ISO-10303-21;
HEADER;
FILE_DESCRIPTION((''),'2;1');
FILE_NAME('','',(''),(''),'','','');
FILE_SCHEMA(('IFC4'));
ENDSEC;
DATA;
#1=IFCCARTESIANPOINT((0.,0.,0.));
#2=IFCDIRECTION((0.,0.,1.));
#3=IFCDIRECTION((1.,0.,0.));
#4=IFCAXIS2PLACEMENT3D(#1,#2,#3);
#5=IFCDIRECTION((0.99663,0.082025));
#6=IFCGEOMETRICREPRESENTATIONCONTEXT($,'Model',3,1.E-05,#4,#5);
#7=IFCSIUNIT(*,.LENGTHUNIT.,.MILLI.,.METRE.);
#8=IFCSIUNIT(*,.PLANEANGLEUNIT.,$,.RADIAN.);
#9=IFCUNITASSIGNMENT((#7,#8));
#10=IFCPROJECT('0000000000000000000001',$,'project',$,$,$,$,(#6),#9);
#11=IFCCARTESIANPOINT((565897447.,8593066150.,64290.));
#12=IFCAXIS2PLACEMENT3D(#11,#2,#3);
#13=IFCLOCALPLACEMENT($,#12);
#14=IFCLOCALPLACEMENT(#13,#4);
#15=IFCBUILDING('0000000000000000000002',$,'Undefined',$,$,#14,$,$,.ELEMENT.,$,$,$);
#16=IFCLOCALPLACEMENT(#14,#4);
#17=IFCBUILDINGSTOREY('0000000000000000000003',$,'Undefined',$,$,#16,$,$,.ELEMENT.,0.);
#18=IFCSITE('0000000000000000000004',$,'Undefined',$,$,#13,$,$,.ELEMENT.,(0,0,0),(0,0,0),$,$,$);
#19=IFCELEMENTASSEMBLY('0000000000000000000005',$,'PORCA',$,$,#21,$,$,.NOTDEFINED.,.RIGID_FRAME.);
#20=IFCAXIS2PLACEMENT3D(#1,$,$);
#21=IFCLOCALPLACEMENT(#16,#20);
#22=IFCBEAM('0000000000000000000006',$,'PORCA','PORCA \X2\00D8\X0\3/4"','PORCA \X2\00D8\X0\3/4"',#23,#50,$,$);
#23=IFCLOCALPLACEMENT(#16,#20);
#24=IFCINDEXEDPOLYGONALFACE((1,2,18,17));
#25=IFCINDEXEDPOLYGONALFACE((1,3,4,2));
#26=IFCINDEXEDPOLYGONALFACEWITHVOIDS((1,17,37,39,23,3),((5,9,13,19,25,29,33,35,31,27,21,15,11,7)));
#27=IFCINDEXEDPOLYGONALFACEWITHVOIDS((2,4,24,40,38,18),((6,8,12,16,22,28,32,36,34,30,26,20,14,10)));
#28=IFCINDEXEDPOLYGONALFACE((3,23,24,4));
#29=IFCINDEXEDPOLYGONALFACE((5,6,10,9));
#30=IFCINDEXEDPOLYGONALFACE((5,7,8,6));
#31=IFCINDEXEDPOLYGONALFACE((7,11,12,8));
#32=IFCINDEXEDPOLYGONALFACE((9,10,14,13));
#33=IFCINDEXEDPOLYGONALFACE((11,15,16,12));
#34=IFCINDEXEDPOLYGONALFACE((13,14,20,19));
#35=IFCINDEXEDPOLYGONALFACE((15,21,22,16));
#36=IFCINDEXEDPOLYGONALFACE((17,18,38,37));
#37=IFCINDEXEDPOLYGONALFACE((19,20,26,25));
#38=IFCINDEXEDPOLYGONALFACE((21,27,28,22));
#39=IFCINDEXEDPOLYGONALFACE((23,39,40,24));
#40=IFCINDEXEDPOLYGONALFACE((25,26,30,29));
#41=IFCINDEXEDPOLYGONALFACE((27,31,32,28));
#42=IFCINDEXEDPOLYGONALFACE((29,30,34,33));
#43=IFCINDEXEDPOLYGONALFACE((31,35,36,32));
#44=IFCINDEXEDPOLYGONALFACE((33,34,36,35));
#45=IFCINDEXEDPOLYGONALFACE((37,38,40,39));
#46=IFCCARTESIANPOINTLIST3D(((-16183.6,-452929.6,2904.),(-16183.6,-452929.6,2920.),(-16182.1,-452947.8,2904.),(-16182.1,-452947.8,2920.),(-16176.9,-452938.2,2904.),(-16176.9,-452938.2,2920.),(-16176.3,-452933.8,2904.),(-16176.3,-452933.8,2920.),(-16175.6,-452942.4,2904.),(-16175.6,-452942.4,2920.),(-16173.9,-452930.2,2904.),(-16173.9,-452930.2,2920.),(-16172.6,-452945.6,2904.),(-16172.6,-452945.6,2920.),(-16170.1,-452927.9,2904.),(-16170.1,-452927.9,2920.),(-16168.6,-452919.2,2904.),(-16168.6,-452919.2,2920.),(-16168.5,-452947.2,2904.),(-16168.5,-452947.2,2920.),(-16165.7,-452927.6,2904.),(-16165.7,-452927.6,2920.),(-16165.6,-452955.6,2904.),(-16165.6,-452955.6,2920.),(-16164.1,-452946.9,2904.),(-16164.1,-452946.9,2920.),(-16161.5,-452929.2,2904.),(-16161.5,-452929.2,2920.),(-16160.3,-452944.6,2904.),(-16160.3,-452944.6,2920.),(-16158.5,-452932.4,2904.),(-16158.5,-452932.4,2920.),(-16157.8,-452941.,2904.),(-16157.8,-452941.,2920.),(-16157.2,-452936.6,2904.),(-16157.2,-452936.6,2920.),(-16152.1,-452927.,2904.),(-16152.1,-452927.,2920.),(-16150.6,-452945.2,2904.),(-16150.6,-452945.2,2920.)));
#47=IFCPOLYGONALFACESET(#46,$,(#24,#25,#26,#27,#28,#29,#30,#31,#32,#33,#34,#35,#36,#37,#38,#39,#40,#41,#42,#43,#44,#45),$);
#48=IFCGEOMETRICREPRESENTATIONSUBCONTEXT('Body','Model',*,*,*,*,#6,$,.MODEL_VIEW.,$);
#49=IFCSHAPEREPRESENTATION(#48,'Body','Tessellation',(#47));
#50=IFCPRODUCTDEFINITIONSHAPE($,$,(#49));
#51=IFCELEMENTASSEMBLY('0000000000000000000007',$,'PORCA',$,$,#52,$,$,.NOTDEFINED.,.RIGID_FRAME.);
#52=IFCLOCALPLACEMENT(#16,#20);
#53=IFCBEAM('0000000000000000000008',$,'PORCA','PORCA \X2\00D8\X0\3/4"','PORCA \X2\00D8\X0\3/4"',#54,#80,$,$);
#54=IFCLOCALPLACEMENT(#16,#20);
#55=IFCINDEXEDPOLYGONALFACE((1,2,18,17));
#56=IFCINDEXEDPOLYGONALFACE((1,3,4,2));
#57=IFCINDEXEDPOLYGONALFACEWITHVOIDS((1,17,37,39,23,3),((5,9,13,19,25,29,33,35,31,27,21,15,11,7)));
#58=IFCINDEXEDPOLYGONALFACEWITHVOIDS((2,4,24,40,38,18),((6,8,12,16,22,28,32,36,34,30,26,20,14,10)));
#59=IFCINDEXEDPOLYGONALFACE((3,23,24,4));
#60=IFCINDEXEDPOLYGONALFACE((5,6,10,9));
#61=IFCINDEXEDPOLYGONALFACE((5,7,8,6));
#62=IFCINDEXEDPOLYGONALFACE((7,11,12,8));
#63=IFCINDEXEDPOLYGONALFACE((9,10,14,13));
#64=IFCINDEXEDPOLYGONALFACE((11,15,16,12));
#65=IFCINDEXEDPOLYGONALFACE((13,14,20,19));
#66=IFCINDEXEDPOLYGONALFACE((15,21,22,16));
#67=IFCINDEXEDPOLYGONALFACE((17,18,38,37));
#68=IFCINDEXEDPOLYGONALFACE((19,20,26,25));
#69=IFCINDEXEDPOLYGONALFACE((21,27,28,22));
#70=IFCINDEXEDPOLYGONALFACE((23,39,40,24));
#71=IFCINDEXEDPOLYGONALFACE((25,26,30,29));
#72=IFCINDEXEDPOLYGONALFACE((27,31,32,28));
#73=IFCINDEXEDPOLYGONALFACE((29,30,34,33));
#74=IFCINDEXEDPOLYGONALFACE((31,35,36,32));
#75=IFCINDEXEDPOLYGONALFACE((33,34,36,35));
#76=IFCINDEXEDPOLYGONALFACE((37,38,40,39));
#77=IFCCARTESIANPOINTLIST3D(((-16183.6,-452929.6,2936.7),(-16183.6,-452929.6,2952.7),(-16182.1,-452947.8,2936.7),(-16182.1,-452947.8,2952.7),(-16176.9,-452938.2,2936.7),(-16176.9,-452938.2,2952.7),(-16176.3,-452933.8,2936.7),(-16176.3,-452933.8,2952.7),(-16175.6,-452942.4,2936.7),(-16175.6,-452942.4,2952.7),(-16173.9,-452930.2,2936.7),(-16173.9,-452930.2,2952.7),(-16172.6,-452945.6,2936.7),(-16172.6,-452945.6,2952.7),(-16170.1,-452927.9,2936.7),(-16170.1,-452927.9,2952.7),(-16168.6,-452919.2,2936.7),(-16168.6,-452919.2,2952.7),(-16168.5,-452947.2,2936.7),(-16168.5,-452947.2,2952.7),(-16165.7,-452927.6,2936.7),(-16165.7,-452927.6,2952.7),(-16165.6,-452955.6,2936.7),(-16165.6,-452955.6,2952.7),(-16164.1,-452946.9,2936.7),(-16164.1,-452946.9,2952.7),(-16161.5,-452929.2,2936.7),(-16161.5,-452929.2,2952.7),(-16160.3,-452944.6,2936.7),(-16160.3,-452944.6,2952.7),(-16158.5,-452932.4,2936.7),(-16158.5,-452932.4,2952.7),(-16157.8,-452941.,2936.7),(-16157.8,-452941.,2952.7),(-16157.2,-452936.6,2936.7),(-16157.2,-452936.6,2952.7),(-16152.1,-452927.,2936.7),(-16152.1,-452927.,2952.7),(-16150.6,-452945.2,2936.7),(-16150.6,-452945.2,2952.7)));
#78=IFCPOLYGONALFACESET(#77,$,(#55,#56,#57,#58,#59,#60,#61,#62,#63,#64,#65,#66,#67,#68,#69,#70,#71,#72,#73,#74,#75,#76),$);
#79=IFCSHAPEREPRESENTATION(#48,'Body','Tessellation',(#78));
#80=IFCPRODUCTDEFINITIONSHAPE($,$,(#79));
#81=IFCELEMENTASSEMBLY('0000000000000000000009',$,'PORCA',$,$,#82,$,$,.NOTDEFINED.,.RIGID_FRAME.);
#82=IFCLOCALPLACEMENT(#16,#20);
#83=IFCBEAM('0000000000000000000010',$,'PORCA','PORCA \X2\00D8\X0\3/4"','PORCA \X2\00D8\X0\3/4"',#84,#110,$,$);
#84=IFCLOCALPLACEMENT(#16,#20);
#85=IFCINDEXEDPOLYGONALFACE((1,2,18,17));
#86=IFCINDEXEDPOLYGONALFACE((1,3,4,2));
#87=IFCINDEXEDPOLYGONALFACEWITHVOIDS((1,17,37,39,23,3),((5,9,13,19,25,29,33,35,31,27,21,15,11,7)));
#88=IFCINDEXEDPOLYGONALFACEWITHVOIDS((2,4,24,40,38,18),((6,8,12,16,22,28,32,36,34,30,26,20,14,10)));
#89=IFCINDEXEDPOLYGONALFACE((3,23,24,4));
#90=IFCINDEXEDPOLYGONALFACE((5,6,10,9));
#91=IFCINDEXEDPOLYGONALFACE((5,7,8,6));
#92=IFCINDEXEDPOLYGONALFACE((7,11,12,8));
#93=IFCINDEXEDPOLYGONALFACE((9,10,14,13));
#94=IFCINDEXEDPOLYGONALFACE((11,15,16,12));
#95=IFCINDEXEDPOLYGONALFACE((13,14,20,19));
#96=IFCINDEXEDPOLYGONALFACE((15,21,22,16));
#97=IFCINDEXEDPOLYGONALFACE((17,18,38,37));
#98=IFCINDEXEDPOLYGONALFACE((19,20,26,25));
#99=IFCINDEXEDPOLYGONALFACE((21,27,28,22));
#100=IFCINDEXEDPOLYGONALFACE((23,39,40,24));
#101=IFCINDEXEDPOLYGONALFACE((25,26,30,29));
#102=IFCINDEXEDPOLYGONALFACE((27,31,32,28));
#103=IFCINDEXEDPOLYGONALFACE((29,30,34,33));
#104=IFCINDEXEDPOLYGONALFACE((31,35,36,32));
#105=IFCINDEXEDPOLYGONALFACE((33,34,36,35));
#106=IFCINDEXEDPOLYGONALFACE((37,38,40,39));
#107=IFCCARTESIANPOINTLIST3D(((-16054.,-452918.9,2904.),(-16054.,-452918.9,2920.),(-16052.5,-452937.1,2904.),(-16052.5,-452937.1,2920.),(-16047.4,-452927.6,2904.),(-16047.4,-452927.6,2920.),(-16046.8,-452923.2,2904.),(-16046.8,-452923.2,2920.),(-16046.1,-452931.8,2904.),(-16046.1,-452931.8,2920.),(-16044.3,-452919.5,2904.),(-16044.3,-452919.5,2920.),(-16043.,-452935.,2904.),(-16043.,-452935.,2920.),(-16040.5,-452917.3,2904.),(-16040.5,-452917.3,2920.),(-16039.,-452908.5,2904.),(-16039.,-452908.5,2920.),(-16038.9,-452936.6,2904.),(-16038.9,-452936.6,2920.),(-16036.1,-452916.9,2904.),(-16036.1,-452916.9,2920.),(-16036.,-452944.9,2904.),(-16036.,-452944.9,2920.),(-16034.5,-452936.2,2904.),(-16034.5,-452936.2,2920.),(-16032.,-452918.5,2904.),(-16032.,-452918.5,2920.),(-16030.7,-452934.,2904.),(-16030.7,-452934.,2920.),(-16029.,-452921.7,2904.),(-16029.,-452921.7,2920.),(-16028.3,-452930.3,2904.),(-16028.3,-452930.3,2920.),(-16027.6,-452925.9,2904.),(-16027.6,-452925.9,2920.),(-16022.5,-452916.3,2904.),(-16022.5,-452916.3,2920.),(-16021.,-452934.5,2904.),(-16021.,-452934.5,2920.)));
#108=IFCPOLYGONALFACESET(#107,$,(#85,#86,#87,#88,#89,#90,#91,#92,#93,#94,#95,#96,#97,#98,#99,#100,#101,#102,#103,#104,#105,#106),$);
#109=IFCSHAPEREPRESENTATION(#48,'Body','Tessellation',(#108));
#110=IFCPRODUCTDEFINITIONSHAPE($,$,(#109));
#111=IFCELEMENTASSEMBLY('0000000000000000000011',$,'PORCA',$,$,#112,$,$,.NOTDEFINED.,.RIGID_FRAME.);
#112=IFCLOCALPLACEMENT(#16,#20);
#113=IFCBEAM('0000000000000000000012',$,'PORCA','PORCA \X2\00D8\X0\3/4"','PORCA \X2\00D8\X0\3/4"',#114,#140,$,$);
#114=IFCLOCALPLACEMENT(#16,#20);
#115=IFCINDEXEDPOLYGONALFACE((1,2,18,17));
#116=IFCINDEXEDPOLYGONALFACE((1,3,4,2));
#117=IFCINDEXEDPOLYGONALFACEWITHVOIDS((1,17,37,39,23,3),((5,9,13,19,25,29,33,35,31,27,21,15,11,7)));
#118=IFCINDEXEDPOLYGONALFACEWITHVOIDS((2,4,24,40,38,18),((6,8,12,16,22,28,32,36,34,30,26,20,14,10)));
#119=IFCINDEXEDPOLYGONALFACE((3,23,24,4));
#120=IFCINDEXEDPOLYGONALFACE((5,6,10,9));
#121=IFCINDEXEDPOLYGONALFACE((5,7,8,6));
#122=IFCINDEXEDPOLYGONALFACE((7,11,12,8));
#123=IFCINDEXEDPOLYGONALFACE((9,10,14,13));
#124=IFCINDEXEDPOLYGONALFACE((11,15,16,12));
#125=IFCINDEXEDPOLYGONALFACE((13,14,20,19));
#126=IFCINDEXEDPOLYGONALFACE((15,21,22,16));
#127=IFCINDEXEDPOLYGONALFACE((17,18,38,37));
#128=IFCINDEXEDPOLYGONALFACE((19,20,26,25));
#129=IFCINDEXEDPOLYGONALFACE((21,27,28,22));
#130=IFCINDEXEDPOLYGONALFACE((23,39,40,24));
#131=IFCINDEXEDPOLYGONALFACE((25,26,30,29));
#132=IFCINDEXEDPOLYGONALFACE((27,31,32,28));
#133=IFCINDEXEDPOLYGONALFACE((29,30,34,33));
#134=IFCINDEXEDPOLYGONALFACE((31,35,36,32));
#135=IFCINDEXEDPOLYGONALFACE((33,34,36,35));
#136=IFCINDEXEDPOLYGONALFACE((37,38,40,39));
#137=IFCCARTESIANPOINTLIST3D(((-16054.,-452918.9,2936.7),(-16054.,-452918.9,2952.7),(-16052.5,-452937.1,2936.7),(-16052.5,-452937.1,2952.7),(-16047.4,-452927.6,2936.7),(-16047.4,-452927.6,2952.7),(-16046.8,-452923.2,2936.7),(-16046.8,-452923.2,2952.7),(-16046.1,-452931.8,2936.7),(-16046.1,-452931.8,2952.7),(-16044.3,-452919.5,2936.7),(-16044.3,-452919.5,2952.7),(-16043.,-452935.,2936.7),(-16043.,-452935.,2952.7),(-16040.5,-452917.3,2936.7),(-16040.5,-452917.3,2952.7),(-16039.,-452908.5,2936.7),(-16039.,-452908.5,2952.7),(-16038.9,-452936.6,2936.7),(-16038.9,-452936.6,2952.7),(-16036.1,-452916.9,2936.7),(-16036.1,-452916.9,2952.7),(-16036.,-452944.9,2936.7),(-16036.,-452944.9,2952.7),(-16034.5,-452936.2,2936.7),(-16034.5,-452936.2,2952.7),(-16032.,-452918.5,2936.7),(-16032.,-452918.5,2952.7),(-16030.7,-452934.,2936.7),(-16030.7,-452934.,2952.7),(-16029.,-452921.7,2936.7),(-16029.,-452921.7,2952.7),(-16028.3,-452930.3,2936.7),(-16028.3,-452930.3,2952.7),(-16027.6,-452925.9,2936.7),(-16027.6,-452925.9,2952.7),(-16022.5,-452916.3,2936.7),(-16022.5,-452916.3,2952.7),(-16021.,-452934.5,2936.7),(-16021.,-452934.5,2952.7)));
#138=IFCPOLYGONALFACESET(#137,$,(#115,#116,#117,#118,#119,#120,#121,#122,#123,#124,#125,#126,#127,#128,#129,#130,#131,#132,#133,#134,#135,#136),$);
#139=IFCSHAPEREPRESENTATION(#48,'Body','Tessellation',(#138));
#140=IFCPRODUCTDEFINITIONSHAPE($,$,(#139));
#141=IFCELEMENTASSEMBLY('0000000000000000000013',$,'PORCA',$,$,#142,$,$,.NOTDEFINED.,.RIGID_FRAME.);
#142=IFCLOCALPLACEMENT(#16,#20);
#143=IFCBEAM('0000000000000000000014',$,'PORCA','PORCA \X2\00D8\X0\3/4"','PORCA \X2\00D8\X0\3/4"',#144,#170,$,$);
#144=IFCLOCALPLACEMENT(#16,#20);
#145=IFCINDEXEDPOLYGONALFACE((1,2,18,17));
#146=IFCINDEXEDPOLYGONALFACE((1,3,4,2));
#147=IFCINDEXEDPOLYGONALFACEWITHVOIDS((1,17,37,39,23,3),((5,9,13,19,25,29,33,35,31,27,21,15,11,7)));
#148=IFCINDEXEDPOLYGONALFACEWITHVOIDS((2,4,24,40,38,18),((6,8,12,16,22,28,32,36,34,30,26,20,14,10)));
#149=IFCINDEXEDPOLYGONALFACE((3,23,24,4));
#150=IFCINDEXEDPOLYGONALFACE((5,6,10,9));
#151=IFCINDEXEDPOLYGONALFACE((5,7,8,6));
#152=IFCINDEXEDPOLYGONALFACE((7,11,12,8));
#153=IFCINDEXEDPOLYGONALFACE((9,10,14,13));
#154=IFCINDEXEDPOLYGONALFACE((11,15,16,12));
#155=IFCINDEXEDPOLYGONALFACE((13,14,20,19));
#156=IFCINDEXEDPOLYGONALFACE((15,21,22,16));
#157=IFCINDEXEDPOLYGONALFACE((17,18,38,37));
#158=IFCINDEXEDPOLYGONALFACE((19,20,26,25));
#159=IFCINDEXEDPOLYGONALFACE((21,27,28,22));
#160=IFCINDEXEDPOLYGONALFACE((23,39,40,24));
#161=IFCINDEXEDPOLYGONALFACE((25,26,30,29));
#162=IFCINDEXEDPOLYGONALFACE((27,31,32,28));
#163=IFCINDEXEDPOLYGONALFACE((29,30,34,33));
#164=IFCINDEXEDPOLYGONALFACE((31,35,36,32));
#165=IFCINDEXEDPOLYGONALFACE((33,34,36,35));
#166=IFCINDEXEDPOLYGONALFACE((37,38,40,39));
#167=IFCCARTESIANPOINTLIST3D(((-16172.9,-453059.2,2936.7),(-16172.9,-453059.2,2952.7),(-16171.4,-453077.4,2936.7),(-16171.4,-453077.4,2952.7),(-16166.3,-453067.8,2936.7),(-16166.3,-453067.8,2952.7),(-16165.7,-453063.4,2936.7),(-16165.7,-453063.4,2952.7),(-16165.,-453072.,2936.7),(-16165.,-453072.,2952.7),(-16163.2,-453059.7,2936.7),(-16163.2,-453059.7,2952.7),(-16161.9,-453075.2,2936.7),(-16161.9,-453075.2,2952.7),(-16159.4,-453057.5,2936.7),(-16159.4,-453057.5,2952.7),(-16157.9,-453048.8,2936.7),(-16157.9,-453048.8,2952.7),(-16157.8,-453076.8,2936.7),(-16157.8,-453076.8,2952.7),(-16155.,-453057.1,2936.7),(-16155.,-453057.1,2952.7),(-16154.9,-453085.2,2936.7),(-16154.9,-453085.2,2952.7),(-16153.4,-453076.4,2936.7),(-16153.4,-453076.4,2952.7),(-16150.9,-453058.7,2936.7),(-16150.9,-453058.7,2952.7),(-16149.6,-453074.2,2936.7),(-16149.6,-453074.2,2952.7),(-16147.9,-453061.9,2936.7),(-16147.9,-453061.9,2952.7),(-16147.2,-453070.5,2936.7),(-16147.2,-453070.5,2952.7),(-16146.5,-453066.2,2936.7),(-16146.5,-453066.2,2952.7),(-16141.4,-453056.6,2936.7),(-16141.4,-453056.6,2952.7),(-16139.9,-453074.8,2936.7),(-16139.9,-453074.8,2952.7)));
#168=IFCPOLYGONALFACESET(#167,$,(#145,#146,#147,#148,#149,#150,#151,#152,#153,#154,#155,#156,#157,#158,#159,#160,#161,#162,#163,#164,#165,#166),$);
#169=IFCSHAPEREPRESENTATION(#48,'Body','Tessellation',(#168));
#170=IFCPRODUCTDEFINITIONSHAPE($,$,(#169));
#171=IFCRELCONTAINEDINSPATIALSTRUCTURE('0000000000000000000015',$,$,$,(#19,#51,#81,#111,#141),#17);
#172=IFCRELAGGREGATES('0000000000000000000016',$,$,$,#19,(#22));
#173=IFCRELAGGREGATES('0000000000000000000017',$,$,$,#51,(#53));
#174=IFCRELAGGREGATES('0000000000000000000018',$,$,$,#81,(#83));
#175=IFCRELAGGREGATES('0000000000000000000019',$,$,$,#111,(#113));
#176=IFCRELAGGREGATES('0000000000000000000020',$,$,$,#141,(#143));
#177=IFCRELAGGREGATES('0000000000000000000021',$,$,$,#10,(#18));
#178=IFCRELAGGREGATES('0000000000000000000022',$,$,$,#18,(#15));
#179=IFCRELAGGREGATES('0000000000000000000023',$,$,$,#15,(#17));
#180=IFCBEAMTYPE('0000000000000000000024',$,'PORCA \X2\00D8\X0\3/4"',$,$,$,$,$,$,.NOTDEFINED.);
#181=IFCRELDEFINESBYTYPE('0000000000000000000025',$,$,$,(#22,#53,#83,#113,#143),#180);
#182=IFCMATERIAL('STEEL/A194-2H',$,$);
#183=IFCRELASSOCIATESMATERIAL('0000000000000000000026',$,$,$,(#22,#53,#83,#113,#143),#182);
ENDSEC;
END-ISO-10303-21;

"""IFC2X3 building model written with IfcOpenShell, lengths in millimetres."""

from ifc_helpers import new_model, si_unit, direction, frame, origin_with_axes, place, context, subcontext, project, spatial, polyline, outline, extrude, material, type_object, element, aggregate, save


model = new_model("IFC2X3")

# Units and contexts
model_context = context("Model", 3, precision=1e-05, world=origin_with_axes(), true_north=direction((0.99663, 0.082025)))
body_context = subcontext(model_context, "Body", "Model", "MODEL_VIEW")
ifc_project = project(units=[si_unit("LENGTHUNIT", "METRE", prefix="MILLI"), si_unit("PLANEANGLEUNIT", "RADIAN")], contexts=[model_context])

# Site, building, storey
site_placement = place(None, frame((565897447.0, 8593066150.0, 64290.0), z_axis=(0.0, 0.0, 1.0), x_axis=(1.0, 0.0, 0.0)))
site = spatial("IfcSite", under=ifc_project, at=site_placement, Name="Undefined", CompositionType="ELEMENT", RefLatitude=(0, 0, 0), RefLongitude=(0, 0, 0))
building_placement = place(site_placement, origin_with_axes())
building = spatial("IfcBuilding", under=site, at=building_placement, Name="Undefined", CompositionType="ELEMENT")
storey_placement = place(building_placement, origin_with_axes())
storey = spatial("IfcBuildingStorey", under=building, at=storey_placement, Name="Undefined", CompositionType="ELEMENT", Elevation=0.0)

# Element assemblies, beams
assembly_1_placement = place(storey_placement, origin_with_axes())
assembly_1 = element("IfcElementAssembly", 1, at=assembly_1_placement, inside=storey, Name="PORCA", AssemblyPlace="NOTDEFINED", PredefinedType="RIGID_FRAME")
ifc_material_1 = material(Name="STEEL/A194-2H")
beam_type_1 = type_object("IfcBeamType", Name="PORCA Ø3/4\"", PredefinedType="NOTDEFINED")
beam_1_placement = place(assembly_1_placement, frame((-16167.1, -452937.4, 2920.0), z_axis=(0.99663, 0.082025, 0.0), x_axis=(0.0, 0.0, -1.0)))
beam_1 = element("IfcBeam", 2, at=beam_1_placement, type_object=beam_type_1, material=ifc_material_1, Name="PORCA", Description="PORCA Ø3/4\"", ObjectType="PORCA Ø3/4\"", context=body_context, shape_type="SweptSolid", body=[
    extrude(outline(polyline([(-9.1, 15.8), (9.1, 15.8), (18.3, 0.0), (9.1, -15.8), (-9.1, -15.8), (-18.3, 0.0), (-9.1, 15.8)]), holes=[polyline([(7.8, -6.2), (9.7, -2.2), (9.7, 2.2), (7.8, 6.2), (4.3, 8.9), (0.0, 9.9), (-4.3, 8.9), (-7.8, 6.2), (-9.7, 2.2), (-9.7, -2.2), (-7.8, -6.2), (-4.3, -8.9), (0.0, -9.9), (4.3, -8.9), (7.8, -6.2)])]), frame((16.0, 0.0, 0.0), z_axis=(-1.0, 0.0, 0.0), x_axis=(0.0, -1.0, 0.0)), (0.0, 0.0, 1.0), 16.0),
])
aggregate(assembly_1, [beam_1])
assembly_2_placement = place(storey_placement, origin_with_axes())
assembly_2 = element("IfcElementAssembly", 3, at=assembly_2_placement, inside=storey, Name="PORCA", AssemblyPlace="NOTDEFINED", PredefinedType="RIGID_FRAME")
beam_2_placement = place(assembly_2_placement, frame((-16167.1, -452937.4, 2952.7), z_axis=(0.99663, 0.082025, 0.0), x_axis=(0.0, 0.0, -1.0)))
beam_2 = element("IfcBeam", 4, at=beam_2_placement, type_object=beam_type_1, material=ifc_material_1, Name="PORCA", Description="PORCA Ø3/4\"", ObjectType="PORCA Ø3/4\"", context=body_context, shape_type="SweptSolid", body=[
    extrude(outline(polyline([(-9.1, 15.8), (9.1, 15.8), (18.3, 0.0), (9.1, -15.8), (-9.1, -15.8), (-18.3, 0.0), (-9.1, 15.8)]), holes=[polyline([(7.8, -6.2), (9.7, -2.2), (9.7, 2.2), (7.8, 6.2), (4.3, 8.9), (0.0, 9.9), (-4.3, 8.9), (-7.8, 6.2), (-9.7, 2.2), (-9.7, -2.2), (-7.8, -6.2), (-4.3, -8.9), (0.0, -9.9), (4.3, -8.9), (7.8, -6.2)])]), frame((16.0, 0.0, 0.0), z_axis=(-1.0, 0.0, 0.0), x_axis=(0.0, -1.0, 0.0)), (0.0, 0.0, 1.0), 16.0),
])
aggregate(assembly_2, [beam_2])
assembly_3_placement = place(storey_placement, origin_with_axes())
assembly_3 = element("IfcElementAssembly", 5, at=assembly_3_placement, inside=storey, Name="PORCA", AssemblyPlace="NOTDEFINED", PredefinedType="RIGID_FRAME")
beam_3_placement = place(assembly_3_placement, frame((-16037.5, -452926.7, 2920.0), z_axis=(-0.99663, -0.082025, 0.0), x_axis=(0.0, 0.0, -1.0)))
beam_3 = element("IfcBeam", 6, at=beam_3_placement, type_object=beam_type_1, material=ifc_material_1, Name="PORCA", Description="PORCA Ø3/4\"", ObjectType="PORCA Ø3/4\"", context=body_context, shape_type="SweptSolid", body=[
    extrude(outline(polyline([(-9.1, 15.8), (9.1, 15.8), (18.3, 0.0), (9.1, -15.8), (-9.1, -15.8), (-18.3, 0.0), (-9.1, 15.8)]), holes=[polyline([(7.8, -6.2), (9.7, -2.2), (9.7, 2.2), (7.8, 6.2), (4.3, 8.9), (0.0, 9.9), (-4.3, 8.9), (-7.8, 6.2), (-9.7, 2.2), (-9.7, -2.2), (-7.8, -6.2), (-4.3, -8.9), (0.0, -9.9), (4.3, -8.9), (7.8, -6.2)])]), frame((16.0, 0.0, 0.0), z_axis=(-1.0, 0.0, 0.0), x_axis=(0.0, -1.0, 0.0)), (0.0, 0.0, 1.0), 16.0),
])
aggregate(assembly_3, [beam_3])
assembly_4_placement = place(storey_placement, origin_with_axes())
assembly_4 = element("IfcElementAssembly", 7, at=assembly_4_placement, inside=storey, Name="PORCA", AssemblyPlace="NOTDEFINED", PredefinedType="RIGID_FRAME")
beam_4_placement = place(assembly_4_placement, frame((-16037.5, -452926.7, 2952.7), z_axis=(-0.99663, -0.082025, 0.0), x_axis=(0.0, 0.0, -1.0)))
beam_4 = element("IfcBeam", 8, at=beam_4_placement, type_object=beam_type_1, material=ifc_material_1, Name="PORCA", Description="PORCA Ø3/4\"", ObjectType="PORCA Ø3/4\"", context=body_context, shape_type="SweptSolid", body=[
    extrude(outline(polyline([(-9.1, 15.8), (9.1, 15.8), (18.3, 0.0), (9.1, -15.8), (-9.1, -15.8), (-18.3, 0.0), (-9.1, 15.8)]), holes=[polyline([(7.8, -6.2), (9.7, -2.2), (9.7, 2.2), (7.8, 6.2), (4.3, 8.9), (0.0, 9.9), (-4.3, 8.9), (-7.8, 6.2), (-9.7, 2.2), (-9.7, -2.2), (-7.8, -6.2), (-4.3, -8.9), (0.0, -9.9), (4.3, -8.9), (7.8, -6.2)])]), frame((16.0, 0.0, 0.0), z_axis=(-1.0, 0.0, 0.0), x_axis=(0.0, -1.0, 0.0)), (0.0, 0.0, 1.0), 16.0),
])
aggregate(assembly_4, [beam_4])
assembly_5_placement = place(storey_placement, origin_with_axes())
assembly_5 = element("IfcElementAssembly", 9, at=assembly_5_placement, inside=storey, Name="PORCA", AssemblyPlace="NOTDEFINED", PredefinedType="RIGID_FRAME")
beam_5_placement = place(assembly_5_placement, frame((-16156.4, -453067.0, 2952.7), z_axis=(0.99663, 0.082025, 0.0), x_axis=(0.0, 0.0, -1.0)))
beam_5 = element("IfcBeam", 10, at=beam_5_placement, type_object=beam_type_1, material=ifc_material_1, Name="PORCA", Description="PORCA Ø3/4\"", ObjectType="PORCA Ø3/4\"", context=body_context, shape_type="SweptSolid", body=[
    extrude(outline(polyline([(-9.1, 15.8), (9.1, 15.8), (18.3, 0.0), (9.1, -15.8), (-9.1, -15.8), (-18.3, 0.0), (-9.1, 15.8)]), holes=[polyline([(7.8, -6.2), (9.7, -2.2), (9.7, 2.2), (7.8, 6.2), (4.3, 8.9), (0.0, 9.9), (-4.3, 8.9), (-7.8, 6.2), (-9.7, 2.2), (-9.7, -2.2), (-7.8, -6.2), (-4.3, -8.9), (0.0, -9.9), (4.3, -8.9), (7.8, -6.2)])]), frame((16.0, 0.0, 0.0), z_axis=(-1.0, 0.0, 0.0), x_axis=(0.0, -1.0, 0.0)), (0.0, 0.0, 1.0), 16.0),
])
aggregate(assembly_5, [beam_5])

save(model, "model.ifc")
